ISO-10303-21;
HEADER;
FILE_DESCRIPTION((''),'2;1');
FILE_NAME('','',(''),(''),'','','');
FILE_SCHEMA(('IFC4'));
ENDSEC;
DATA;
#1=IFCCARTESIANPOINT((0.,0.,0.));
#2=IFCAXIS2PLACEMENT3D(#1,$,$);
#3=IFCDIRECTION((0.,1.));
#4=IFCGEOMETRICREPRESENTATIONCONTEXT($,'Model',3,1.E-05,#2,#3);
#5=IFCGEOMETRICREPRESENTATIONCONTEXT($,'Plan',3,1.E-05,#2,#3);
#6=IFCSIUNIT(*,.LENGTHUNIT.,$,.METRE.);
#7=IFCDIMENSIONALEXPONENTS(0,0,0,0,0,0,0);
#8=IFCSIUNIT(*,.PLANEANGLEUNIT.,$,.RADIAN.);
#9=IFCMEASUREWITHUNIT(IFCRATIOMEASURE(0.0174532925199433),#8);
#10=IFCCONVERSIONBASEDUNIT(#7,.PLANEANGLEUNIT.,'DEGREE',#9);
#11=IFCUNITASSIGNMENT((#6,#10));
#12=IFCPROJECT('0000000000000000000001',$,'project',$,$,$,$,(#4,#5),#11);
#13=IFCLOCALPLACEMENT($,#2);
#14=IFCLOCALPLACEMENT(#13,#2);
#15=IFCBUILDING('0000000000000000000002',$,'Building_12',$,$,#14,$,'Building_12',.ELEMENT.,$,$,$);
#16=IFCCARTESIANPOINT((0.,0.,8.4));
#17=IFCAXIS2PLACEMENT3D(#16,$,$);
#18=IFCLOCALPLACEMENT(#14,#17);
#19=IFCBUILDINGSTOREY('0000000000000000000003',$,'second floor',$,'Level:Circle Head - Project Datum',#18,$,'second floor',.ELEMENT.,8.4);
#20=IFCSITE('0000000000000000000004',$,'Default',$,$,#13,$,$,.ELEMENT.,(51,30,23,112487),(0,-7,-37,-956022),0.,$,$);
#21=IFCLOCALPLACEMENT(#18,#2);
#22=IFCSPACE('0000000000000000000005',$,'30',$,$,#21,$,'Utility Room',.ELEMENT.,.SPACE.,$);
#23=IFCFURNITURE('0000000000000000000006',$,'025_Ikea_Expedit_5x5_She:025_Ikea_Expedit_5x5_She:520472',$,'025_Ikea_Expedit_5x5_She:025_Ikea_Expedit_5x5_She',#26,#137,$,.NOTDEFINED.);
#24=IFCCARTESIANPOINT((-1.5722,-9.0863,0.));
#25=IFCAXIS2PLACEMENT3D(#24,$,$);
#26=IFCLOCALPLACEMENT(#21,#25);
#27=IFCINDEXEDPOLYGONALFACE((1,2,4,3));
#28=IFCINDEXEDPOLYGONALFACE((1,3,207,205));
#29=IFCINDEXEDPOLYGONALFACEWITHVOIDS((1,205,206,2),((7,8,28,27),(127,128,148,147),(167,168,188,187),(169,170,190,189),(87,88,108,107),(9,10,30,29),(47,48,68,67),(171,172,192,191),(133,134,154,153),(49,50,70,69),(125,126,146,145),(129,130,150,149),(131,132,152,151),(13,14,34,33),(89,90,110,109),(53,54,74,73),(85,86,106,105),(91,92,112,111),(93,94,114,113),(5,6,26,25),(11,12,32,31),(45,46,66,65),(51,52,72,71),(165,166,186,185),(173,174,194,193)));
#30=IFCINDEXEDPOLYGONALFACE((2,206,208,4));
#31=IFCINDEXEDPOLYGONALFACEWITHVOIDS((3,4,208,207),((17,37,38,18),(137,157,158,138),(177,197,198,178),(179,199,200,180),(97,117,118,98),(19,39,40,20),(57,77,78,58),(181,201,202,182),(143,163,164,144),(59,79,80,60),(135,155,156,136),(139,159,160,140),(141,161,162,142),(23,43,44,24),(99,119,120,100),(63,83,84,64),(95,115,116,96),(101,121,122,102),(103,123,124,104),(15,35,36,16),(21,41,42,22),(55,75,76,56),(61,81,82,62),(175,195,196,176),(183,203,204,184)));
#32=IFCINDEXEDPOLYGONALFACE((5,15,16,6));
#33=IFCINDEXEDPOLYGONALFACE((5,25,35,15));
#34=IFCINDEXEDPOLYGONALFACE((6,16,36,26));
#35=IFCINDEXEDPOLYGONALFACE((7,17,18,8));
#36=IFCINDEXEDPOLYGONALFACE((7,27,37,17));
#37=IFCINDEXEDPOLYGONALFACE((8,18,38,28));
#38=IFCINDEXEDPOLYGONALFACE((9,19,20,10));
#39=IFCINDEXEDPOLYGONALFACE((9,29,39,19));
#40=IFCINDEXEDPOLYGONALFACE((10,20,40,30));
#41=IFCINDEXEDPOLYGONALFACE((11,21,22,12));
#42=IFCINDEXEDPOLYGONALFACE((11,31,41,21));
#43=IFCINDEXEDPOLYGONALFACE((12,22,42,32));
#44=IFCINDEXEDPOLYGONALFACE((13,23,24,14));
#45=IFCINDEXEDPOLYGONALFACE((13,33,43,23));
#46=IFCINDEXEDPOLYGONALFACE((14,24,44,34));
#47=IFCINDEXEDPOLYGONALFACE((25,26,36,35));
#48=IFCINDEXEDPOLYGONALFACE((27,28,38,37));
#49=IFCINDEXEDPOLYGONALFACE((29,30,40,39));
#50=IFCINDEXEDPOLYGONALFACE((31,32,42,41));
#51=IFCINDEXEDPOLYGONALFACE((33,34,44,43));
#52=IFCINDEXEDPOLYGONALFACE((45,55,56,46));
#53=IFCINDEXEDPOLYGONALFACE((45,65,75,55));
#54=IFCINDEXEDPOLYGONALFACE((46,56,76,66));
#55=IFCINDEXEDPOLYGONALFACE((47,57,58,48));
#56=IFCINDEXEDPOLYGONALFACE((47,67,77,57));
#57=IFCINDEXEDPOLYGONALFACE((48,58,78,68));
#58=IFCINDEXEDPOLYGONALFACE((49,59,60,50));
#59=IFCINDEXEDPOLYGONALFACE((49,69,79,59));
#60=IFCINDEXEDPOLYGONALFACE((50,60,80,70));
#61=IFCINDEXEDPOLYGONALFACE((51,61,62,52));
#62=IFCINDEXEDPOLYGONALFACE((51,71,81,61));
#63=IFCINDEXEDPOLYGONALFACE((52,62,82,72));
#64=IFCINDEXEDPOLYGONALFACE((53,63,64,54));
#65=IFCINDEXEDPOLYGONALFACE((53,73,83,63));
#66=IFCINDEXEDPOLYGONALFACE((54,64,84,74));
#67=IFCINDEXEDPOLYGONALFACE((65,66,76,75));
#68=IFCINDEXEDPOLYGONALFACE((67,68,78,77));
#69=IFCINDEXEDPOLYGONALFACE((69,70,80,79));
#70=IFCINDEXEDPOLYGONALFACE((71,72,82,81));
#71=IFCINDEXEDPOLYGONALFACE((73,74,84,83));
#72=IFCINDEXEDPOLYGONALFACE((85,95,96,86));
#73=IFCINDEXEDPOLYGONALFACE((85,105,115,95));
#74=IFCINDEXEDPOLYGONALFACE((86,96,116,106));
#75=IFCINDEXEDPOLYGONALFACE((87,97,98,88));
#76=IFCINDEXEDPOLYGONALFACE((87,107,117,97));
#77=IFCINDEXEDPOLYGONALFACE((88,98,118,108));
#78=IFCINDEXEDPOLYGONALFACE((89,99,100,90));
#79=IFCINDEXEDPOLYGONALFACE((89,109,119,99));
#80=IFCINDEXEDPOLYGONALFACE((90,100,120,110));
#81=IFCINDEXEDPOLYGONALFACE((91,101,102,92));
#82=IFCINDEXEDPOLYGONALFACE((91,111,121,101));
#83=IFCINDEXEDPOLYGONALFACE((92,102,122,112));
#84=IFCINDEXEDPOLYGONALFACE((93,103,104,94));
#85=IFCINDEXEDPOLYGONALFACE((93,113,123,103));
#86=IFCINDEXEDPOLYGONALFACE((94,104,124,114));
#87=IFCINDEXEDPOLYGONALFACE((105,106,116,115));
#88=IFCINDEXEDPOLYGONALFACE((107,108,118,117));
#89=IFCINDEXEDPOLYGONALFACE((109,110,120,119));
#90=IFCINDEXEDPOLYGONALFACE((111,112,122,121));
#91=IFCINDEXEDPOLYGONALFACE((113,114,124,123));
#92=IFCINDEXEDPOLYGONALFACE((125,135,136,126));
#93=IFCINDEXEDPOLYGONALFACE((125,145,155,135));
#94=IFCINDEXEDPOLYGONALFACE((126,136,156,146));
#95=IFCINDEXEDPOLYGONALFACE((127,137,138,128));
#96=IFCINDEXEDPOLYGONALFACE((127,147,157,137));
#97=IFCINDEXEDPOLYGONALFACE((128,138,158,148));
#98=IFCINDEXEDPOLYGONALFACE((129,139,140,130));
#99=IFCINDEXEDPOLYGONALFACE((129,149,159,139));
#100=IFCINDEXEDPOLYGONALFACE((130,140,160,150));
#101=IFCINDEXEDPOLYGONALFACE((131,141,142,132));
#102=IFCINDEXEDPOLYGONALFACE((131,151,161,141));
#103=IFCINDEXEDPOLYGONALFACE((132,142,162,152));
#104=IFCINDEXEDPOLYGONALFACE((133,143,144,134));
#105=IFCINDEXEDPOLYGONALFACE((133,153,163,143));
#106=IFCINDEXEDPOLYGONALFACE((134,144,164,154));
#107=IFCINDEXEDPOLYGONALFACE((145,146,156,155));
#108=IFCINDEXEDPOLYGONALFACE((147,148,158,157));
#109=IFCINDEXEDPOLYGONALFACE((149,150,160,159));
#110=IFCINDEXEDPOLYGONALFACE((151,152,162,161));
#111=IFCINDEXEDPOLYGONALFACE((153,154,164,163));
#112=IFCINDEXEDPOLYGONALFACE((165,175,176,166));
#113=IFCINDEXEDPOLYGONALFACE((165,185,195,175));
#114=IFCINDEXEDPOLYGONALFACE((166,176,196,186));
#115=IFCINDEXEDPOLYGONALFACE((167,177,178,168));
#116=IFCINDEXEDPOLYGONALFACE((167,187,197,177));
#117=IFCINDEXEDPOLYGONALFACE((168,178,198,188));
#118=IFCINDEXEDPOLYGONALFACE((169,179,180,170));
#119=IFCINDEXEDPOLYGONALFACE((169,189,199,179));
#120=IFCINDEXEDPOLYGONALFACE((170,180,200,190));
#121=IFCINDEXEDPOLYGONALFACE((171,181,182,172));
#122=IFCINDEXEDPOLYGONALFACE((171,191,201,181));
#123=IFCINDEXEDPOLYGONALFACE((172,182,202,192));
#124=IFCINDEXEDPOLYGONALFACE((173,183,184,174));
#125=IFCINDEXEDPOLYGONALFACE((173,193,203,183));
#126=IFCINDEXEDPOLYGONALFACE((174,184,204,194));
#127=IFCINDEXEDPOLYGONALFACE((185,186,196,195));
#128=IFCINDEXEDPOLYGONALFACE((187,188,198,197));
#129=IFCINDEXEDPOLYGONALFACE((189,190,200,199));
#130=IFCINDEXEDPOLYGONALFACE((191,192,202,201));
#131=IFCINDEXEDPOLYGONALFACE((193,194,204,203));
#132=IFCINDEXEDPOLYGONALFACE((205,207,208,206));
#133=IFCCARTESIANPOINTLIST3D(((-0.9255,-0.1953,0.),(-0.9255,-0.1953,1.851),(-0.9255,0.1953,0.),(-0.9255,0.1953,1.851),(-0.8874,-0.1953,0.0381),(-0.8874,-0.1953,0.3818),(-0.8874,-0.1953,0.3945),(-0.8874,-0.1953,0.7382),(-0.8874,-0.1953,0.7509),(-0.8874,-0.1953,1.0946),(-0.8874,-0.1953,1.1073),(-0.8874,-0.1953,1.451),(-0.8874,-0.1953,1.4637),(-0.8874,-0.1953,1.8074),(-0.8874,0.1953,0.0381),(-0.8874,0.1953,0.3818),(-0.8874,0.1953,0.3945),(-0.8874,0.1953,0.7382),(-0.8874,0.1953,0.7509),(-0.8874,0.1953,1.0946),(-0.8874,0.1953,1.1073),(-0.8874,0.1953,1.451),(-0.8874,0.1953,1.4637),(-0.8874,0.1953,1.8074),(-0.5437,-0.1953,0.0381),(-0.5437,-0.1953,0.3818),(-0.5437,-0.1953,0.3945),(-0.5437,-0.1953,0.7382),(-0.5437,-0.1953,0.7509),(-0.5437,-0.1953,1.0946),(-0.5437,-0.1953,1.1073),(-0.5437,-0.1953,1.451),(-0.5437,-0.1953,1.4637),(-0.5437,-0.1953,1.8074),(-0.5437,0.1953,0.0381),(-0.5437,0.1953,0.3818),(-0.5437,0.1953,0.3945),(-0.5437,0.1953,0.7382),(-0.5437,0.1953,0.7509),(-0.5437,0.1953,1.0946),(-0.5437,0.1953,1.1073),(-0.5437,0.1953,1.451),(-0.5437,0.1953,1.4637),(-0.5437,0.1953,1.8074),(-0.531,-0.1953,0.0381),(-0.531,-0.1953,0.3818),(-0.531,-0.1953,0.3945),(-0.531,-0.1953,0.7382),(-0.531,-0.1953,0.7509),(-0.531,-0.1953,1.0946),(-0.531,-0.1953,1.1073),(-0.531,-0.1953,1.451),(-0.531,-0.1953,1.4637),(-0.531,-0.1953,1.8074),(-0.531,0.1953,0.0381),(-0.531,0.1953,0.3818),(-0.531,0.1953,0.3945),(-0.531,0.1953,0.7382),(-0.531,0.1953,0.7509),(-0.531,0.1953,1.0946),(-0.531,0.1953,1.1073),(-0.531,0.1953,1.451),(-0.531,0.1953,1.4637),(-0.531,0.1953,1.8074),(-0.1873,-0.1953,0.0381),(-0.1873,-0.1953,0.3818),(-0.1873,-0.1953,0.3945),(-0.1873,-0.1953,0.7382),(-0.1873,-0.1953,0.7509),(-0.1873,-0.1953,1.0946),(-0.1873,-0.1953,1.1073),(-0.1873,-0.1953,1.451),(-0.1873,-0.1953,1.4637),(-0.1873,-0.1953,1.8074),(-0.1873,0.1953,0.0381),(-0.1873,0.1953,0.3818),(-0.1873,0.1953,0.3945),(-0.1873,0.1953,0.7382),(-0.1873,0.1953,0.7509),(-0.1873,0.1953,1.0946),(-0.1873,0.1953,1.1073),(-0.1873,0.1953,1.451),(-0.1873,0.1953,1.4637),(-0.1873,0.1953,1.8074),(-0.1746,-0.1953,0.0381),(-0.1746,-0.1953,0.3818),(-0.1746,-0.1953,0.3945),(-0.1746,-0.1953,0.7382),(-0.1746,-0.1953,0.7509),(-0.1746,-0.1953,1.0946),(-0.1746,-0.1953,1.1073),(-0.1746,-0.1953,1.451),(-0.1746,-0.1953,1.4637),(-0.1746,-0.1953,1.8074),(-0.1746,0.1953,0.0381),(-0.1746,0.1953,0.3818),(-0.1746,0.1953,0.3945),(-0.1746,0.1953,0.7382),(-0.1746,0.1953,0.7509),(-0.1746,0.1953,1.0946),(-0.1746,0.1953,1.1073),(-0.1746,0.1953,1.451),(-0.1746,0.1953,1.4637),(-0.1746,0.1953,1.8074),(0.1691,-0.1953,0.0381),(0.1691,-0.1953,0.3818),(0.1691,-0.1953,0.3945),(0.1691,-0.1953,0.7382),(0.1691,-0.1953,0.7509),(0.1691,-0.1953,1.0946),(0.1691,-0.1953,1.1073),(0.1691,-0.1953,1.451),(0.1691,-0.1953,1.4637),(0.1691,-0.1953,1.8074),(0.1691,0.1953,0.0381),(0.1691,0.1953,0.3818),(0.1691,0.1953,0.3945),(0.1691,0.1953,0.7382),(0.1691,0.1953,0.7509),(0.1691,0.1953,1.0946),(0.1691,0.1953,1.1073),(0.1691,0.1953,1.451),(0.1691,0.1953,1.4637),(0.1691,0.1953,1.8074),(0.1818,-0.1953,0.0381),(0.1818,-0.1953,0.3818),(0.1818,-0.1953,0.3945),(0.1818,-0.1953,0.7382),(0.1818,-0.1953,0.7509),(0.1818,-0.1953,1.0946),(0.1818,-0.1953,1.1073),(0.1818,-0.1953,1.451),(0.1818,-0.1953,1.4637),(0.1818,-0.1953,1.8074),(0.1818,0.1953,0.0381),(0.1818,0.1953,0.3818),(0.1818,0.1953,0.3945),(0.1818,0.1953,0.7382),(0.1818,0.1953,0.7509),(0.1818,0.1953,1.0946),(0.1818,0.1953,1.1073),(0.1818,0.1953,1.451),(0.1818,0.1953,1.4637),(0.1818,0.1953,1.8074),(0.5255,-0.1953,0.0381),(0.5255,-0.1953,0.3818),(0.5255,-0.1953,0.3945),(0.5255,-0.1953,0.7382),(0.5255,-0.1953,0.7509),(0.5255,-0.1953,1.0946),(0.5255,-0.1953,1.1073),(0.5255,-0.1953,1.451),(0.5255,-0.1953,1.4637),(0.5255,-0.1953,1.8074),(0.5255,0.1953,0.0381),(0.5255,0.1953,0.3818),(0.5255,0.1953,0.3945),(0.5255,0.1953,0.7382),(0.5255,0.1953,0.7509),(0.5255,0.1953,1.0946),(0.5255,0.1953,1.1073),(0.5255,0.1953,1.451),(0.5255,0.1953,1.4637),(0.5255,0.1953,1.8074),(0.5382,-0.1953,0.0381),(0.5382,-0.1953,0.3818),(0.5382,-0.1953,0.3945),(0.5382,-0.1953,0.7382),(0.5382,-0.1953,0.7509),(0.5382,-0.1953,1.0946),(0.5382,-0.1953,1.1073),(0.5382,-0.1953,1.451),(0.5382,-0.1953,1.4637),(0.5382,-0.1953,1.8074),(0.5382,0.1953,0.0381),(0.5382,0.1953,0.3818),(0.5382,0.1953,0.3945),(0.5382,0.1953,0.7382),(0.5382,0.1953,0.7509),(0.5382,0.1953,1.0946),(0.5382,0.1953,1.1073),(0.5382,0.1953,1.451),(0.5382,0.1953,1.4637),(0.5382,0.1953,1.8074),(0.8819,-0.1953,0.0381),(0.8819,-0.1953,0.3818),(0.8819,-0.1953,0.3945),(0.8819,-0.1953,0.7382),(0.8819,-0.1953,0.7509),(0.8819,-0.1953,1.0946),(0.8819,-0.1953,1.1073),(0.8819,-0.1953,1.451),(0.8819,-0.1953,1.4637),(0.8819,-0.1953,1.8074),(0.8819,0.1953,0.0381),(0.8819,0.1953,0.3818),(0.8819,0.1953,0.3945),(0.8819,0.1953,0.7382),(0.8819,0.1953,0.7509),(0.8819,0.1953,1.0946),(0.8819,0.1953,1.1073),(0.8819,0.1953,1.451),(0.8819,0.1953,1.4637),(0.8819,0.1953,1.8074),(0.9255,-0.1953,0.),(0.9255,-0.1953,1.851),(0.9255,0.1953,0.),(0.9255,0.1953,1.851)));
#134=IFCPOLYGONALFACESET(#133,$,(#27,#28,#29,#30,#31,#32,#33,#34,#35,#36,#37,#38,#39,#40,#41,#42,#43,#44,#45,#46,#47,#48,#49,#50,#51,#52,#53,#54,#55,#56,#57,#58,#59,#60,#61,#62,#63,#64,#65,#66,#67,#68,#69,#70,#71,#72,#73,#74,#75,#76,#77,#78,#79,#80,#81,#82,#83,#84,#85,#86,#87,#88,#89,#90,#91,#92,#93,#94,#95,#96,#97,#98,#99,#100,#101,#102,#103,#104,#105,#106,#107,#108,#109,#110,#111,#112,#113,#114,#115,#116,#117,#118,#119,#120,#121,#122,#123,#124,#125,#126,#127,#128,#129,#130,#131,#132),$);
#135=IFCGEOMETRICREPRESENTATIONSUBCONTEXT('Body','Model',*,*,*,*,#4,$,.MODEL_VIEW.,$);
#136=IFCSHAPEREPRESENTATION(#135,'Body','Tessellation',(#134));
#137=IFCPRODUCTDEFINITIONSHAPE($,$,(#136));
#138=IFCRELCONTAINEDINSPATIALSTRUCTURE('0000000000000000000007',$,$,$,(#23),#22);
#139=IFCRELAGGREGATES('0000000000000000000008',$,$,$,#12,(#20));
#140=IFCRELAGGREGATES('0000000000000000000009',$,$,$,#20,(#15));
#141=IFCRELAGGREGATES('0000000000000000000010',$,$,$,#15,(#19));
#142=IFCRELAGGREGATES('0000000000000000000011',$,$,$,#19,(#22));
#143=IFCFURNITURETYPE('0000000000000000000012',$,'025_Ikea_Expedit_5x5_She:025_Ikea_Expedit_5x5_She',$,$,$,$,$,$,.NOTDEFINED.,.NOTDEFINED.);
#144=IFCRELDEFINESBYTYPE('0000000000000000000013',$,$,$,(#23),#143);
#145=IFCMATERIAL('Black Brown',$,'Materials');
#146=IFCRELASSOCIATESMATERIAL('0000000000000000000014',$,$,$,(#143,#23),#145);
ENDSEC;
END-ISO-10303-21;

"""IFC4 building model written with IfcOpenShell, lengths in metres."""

from ifc_helpers import new_model, entity, si_unit, converted_unit, direction, frame, origin, place, context, subcontext, project, spatial, indexed_curve, outline, extrude, source, transform, mapped, material, type_object, type_shapes, element, save


model = new_model("IFC4")

# Units and contexts
model_context = context("Model", 3, precision=1e-05, world=origin(), true_north=direction((0.0, 1.0)))
plan_context = context("Plan", 3, precision=1e-05, world=origin(), true_north=direction((0.0, 1.0)))
body_context = subcontext(model_context, "Body", "Model", "MODEL_VIEW")
ifc_project = project(units=[si_unit("LENGTHUNIT", "METRE"), converted_unit("PLANEANGLEUNIT", "DEGREE", entity("IfcRatioMeasure", 0.0174532925199433), si_unit("PLANEANGLEUNIT", "RADIAN"), dimensions=[0, 0, 0, 0, 0, 0, 0])], contexts=[model_context, plan_context])

# Site, building, storey
site_placement = place(None, origin())
site = spatial("IfcSite", under=ifc_project, at=site_placement, Name="Default", CompositionType="ELEMENT", RefLatitude=(51, 30, 23, 112487), RefLongitude=(0, -7, -37, -956022), RefElevation=0.0)
building_placement = place(site_placement, origin())
building = spatial("IfcBuilding", under=site, at=building_placement, Name="Building_12", LongName="Building_12", CompositionType="ELEMENT")
storey_placement = place(building_placement, frame((0.0, 0.0, 8.4)))
storey = spatial("IfcBuildingStorey", under=building, at=storey_placement, Name="second floor", ObjectType="Level:Circle Head - Project Datum", LongName="second floor", CompositionType="ELEMENT", Elevation=8.4)

# Shared definitions
space_placement = place(storey_placement, origin())
space = spatial("IfcSpace", under=storey, at=space_placement, Name="30", LongName="Utility Room", CompositionType="ELEMENT", PredefinedType="SPACE")

# Furniture
ifc_material_1 = material(Name="Black Brown", Category="Materials")
furniture_type = type_object("IfcFurnitureType", Name="025_Ikea_Expedit_5x5_She:025_Ikea_Expedit_5x5_She", AssemblyPlace="NOTDEFINED", PredefinedType="NOTDEFINED", material=ifc_material_1)
shared_shape = source(origin(), body_context, "Body", "SweptSolid", [
    extrude(outline(indexed_curve([(-0.9255, -0.9255), (0.9255, -0.9255), (0.9255, 0.9255), (-0.9255, 0.9255), (-0.9255, -0.9255)], self_intersect=False), holes=[indexed_curve([(-0.5255, 0.8874), (-0.1818, 0.8874), (-0.1818, 0.5437), (-0.5255, 0.5437), (-0.5255, 0.8874)], self_intersect=False), indexed_curve([(0.1746, 0.8874), (0.1746, 0.5437), (-0.1691, 0.5437), (-0.1691, 0.8874), (0.1746, 0.8874)], self_intersect=False), indexed_curve([(-0.5255, 0.1873), (-0.5255, 0.531), (-0.1818, 0.531), (-0.1818, 0.1873), (-0.5255, 0.1873)], self_intersect=False), indexed_curve([(-0.1691, 0.1873), (-0.1691, 0.531), (0.1746, 0.531), (0.1746, 0.1873), (-0.1691, 0.1873)], self_intersect=False), indexed_curve([(-0.1818, -0.1818), (-0.1818, -0.5255), (-0.5255, -0.5255), (-0.5255, -0.1818), (-0.1818, -0.1818)], self_intersect=False), indexed_curve([(-0.1691, -0.1818), (0.1746, -0.1818), (0.1746, -0.5255), (-0.1691, -0.5255), (-0.1691, -0.1818)], self_intersect=False), indexed_curve([(-0.1818, -0.1691), (-0.5255, -0.1691), (-0.5255, 0.1746), (-0.1818, 0.1746), (-0.1818, -0.1691)], self_intersect=False), indexed_curve([(0.1746, -0.1691), (-0.1691, -0.1691), (-0.1691, 0.1746), (0.1746, 0.1746), (0.1746, -0.1691)], self_intersect=False), indexed_curve([(0.5437, 0.5437), (0.5437, 0.8874), (0.8874, 0.8874), (0.8874, 0.5437), (0.5437, 0.5437)], self_intersect=False), indexed_curve([(0.531, 0.5437), (0.1873, 0.5437), (0.1873, 0.8874), (0.531, 0.8874), (0.531, 0.5437)], self_intersect=False), indexed_curve([(0.5437, 0.531), (0.8874, 0.531), (0.8874, 0.1873), (0.5437, 0.1873), (0.5437, 0.531)], self_intersect=False), indexed_curve([(0.1873, 0.531), (0.531, 0.531), (0.531, 0.1873), (0.1873, 0.1873), (0.1873, 0.531)], self_intersect=False), indexed_curve([(0.8874, -0.5255), (0.5437, -0.5255), (0.5437, -0.1818), (0.8874, -0.1818), (0.8874, -0.5255)], self_intersect=False), indexed_curve([(0.1873, -0.5255), (0.1873, -0.1818), (0.531, -0.1818), (0.531, -0.5255), (0.1873, -0.5255)], self_intersect=False), indexed_curve([(0.8874, 0.1746), (0.8874, -0.1691), (0.5437, -0.1691), (0.5437, 0.1746), (0.8874, 0.1746)], self_intersect=False), indexed_curve([(0.531, 0.1746), (0.531, -0.1691), (0.1873, -0.1691), (0.1873, 0.1746), (0.531, 0.1746)], self_intersect=False), indexed_curve([(-0.1818, -0.5382), (-0.1818, -0.8819), (-0.5255, -0.8819), (-0.5255, -0.5382), (-0.1818, -0.5382)], self_intersect=False), indexed_curve([(-0.1691, -0.5382), (0.1746, -0.5382), (0.1746, -0.8819), (-0.1691, -0.8819), (-0.1691, -0.5382)], self_intersect=False), indexed_curve([(0.8874, -0.8819), (0.5437, -0.8819), (0.5437, -0.5382), (0.8874, -0.5382), (0.8874, -0.8819)], self_intersect=False), indexed_curve([(0.1873, -0.8819), (0.1873, -0.5382), (0.531, -0.5382), (0.531, -0.8819), (0.1873, -0.8819)], self_intersect=False), indexed_curve([(-0.8819, 0.8874), (-0.5382, 0.8874), (-0.5382, 0.5437), (-0.8819, 0.5437), (-0.8819, 0.8874)], self_intersect=False), indexed_curve([(-0.8819, 0.1873), (-0.8819, 0.531), (-0.5382, 0.531), (-0.5382, 0.1873), (-0.8819, 0.1873)], self_intersect=False), indexed_curve([(-0.5382, -0.1818), (-0.5382, -0.5255), (-0.8819, -0.5255), (-0.8819, -0.1818), (-0.5382, -0.1818)], self_intersect=False), indexed_curve([(-0.5382, -0.1691), (-0.8819, -0.1691), (-0.8819, 0.1746), (-0.5382, 0.1746), (-0.5382, -0.1691)], self_intersect=False), indexed_curve([(-0.5382, -0.5382), (-0.5382, -0.8819), (-0.8819, -0.8819), (-0.8819, -0.5382), (-0.5382, -0.5382)], self_intersect=False)]), frame((0.0, -0.1953, 0.9255), z_axis=(0.0, 1.0, 0.0), x_axis=(0.0, 0.0, -1.0)), (0.0, 0.0, 1.0), 0.3905),
])
type_shapes(furniture_type, [shared_shape])
furniture_placement = place(space_placement, frame((-1.5722, -9.0863, 0.0)))
element("IfcFurniture", 1, at=furniture_placement, inside=space, type_object=furniture_type, material=ifc_material_1, Name="025_Ikea_Expedit_5x5_She:025_Ikea_Expedit_5x5_She:520472", ObjectType="025_Ikea_Expedit_5x5_She:025_Ikea_Expedit_5x5_She", PredefinedType="NOTDEFINED", context=body_context, shape_type="MappedRepresentation", body=[
    mapped(shared_shape, transform((0.0, 0.0, 0.0), scale=1.0)),
])

save(model, "model.ifc")
